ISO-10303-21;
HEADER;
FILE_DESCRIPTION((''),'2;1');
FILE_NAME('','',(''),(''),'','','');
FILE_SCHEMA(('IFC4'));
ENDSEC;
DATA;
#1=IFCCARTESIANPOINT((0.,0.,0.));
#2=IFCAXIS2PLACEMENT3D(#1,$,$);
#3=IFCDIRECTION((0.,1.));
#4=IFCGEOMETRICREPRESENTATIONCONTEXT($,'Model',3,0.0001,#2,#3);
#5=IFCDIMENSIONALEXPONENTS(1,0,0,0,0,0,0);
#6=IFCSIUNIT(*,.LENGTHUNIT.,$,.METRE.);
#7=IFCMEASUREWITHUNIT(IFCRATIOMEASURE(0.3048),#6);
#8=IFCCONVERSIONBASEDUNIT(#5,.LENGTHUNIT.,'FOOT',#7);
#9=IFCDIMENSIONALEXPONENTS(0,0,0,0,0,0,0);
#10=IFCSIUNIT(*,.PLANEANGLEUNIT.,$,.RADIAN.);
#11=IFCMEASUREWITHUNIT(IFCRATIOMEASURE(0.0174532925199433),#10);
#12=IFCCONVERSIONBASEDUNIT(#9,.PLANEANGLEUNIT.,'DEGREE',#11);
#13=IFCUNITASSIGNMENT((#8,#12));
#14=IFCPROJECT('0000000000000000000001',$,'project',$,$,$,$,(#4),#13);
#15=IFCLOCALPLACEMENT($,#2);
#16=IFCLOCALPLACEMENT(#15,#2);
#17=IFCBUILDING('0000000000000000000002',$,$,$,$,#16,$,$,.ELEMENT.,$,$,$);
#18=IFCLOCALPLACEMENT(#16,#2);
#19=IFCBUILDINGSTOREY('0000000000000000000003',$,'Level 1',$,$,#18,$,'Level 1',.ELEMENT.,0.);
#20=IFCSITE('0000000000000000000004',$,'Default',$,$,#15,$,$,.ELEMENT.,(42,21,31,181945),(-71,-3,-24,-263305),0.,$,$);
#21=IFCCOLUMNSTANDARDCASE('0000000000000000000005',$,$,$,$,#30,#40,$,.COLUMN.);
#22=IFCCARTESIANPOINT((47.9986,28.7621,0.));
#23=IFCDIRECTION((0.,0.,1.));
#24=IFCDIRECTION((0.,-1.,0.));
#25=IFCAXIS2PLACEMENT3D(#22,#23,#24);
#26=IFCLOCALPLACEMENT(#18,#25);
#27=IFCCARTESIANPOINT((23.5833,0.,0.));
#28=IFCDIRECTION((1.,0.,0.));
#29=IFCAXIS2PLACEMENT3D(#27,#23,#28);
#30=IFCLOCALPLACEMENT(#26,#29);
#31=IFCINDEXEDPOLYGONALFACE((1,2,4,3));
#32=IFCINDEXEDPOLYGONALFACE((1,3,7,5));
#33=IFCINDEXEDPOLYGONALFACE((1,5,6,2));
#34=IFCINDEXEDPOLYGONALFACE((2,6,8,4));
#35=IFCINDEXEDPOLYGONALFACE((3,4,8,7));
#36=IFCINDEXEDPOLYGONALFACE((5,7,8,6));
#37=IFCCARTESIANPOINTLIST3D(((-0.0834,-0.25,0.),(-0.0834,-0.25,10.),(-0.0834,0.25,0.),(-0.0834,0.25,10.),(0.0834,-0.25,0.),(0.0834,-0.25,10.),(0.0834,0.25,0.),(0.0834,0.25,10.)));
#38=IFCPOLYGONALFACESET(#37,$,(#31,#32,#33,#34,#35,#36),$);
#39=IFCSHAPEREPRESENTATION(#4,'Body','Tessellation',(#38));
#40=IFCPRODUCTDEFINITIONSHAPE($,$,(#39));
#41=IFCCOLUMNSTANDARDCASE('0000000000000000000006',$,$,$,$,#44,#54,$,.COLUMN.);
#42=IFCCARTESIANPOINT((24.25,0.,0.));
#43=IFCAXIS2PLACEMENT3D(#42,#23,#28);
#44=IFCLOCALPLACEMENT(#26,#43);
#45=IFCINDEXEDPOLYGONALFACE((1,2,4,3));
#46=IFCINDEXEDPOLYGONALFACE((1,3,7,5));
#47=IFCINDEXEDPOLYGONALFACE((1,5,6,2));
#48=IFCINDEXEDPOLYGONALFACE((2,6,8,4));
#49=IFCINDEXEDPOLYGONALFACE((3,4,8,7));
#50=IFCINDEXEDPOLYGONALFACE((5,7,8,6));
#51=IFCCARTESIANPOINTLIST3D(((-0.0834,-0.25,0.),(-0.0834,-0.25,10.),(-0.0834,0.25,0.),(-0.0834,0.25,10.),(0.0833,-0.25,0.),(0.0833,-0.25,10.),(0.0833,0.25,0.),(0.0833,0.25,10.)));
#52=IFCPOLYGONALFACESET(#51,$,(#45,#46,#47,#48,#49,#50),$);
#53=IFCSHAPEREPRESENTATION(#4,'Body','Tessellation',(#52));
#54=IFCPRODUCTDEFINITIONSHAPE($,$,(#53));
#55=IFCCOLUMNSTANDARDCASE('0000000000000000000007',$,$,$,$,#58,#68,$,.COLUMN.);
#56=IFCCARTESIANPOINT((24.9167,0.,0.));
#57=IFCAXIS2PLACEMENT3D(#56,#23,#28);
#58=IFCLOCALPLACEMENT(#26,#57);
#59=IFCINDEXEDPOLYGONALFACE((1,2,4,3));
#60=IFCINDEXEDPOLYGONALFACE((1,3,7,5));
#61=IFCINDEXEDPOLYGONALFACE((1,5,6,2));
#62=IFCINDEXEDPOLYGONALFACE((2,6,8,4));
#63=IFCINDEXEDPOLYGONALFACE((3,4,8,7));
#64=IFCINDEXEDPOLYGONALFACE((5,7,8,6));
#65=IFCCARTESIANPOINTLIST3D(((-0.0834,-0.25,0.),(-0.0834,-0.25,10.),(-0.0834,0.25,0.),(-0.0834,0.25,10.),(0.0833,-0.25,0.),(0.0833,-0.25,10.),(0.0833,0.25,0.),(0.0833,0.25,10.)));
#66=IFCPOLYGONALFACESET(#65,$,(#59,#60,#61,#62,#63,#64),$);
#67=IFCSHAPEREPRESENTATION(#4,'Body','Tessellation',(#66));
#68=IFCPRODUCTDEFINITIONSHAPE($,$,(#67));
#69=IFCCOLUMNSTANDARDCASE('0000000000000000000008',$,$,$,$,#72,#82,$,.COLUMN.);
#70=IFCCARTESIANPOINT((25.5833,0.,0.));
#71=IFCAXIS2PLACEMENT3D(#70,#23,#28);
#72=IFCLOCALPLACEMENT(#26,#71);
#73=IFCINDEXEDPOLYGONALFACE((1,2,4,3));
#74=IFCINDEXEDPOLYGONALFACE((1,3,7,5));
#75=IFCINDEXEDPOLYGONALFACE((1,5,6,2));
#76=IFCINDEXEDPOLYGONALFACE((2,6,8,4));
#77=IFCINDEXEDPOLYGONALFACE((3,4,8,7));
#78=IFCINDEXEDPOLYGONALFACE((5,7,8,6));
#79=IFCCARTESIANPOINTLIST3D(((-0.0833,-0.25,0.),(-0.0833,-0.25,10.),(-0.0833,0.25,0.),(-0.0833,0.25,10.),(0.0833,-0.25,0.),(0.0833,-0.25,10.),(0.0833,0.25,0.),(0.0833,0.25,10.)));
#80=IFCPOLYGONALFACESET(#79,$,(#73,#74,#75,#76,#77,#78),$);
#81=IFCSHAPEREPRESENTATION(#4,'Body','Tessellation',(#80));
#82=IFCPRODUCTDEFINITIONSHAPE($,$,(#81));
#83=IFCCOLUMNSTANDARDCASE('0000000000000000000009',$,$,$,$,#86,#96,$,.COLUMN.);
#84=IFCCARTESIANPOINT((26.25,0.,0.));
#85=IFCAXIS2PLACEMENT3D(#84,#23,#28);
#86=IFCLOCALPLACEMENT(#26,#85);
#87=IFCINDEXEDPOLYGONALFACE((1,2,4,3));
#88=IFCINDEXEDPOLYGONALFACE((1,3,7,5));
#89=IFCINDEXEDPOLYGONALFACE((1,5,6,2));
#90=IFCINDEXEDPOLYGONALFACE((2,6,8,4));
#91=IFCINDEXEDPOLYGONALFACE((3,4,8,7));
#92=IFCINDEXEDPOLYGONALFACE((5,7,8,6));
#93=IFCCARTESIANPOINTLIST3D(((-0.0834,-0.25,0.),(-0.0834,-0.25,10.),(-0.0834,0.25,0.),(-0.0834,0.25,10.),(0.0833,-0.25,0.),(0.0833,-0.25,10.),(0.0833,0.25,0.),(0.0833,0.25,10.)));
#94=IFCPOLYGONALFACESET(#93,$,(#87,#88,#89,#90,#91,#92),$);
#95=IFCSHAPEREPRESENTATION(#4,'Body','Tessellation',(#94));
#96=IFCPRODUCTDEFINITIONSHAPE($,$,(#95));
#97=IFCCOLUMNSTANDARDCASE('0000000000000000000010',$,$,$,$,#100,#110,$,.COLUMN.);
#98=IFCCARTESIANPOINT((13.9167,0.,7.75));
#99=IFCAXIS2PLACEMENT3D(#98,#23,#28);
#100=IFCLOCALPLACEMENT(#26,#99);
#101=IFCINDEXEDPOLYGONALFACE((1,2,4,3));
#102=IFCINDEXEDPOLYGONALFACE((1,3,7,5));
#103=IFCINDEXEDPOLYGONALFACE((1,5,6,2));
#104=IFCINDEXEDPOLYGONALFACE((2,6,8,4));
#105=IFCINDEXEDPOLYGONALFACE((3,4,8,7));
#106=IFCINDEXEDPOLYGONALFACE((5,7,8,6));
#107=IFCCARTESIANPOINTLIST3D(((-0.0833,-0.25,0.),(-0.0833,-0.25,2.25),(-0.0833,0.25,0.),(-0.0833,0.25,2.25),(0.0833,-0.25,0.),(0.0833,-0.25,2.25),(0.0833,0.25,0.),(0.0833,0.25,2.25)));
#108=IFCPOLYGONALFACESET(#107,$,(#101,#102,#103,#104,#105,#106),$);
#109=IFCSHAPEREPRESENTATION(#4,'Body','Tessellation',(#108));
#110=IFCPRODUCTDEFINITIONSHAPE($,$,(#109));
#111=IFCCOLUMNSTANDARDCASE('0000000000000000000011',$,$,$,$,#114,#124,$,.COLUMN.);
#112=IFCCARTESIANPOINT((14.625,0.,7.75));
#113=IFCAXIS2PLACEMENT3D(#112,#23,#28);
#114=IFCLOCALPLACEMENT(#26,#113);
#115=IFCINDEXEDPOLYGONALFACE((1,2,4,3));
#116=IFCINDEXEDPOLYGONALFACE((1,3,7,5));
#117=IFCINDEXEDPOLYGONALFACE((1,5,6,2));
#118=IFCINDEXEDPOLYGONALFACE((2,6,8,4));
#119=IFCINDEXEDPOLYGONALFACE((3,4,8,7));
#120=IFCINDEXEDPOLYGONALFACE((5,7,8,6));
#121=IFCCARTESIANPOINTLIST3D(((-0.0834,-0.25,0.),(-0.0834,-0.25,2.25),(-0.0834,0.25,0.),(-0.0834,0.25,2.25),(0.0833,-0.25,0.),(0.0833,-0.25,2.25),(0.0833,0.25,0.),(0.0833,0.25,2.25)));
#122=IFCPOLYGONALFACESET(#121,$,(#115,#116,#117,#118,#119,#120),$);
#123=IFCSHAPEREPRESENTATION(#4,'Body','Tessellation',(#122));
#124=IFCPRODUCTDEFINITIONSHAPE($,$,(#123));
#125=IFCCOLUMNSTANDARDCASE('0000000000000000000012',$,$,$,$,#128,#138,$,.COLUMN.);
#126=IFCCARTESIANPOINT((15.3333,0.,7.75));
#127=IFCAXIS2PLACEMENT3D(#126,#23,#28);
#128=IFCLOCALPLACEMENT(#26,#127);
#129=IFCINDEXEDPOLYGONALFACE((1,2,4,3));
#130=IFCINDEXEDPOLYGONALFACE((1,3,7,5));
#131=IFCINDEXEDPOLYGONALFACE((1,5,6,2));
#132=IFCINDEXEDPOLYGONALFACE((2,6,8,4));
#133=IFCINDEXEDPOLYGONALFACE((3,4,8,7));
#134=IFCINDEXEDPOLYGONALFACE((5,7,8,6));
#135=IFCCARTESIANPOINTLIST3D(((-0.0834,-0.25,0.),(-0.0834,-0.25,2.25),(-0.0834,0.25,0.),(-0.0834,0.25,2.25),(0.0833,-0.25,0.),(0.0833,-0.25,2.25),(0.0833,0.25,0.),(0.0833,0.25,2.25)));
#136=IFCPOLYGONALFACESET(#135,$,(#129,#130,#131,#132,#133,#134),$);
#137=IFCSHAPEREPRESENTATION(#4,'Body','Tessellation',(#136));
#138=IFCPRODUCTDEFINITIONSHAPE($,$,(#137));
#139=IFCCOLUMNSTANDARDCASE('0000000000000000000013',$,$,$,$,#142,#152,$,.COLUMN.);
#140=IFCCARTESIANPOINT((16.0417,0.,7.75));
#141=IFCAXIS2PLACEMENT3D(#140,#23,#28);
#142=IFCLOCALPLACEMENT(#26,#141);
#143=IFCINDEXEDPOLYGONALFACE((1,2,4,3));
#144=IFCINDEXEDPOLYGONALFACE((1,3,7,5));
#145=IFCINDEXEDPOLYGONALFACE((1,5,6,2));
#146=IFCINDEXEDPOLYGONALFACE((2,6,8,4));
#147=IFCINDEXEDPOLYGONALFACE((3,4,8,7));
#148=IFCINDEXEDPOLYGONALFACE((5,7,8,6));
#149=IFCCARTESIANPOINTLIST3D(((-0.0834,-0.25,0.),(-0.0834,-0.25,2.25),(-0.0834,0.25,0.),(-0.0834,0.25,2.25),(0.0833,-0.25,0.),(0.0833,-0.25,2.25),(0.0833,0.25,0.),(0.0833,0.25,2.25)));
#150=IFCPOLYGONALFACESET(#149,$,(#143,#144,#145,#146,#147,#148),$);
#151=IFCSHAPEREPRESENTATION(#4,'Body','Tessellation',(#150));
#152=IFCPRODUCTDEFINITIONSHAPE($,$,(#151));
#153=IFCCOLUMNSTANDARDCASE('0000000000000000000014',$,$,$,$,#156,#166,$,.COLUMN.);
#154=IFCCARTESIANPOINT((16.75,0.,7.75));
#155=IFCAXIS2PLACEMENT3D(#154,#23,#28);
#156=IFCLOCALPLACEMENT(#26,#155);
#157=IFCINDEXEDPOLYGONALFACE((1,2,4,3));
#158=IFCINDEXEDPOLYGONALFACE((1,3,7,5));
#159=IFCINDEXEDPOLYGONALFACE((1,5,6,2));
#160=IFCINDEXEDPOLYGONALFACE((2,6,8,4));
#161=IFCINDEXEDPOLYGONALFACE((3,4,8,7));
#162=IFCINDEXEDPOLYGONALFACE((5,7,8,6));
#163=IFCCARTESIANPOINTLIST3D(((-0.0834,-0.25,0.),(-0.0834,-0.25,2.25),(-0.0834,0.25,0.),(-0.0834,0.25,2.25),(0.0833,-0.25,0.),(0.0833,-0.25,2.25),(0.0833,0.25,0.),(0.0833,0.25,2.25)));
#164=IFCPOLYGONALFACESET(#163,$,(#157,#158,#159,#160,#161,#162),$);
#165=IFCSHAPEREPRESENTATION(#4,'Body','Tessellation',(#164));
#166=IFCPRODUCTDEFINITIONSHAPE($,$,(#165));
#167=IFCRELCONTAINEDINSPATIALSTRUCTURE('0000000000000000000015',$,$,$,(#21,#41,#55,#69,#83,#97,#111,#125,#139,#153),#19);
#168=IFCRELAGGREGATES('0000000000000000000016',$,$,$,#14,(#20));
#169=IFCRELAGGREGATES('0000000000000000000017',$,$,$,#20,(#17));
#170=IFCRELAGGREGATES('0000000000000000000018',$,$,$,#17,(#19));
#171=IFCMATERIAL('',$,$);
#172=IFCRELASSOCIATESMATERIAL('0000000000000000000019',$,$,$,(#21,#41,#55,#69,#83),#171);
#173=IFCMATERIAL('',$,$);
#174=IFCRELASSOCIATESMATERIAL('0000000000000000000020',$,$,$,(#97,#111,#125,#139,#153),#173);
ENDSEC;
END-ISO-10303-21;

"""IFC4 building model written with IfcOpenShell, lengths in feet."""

from ifc_helpers import new_model, entity, si_unit, converted_unit, direction, frame, origin, place, context, project, spatial, rectangle, extrude, material, element, save


model = new_model("IFC4")

# Units and contexts
model_context = context("Model", 3, precision=0.0001, world=origin(), true_north=direction((0.0, 1.0)))
ifc_project = project(units=[converted_unit("LENGTHUNIT", "FOOT", entity("IfcRatioMeasure", 0.3048), si_unit("LENGTHUNIT", "METRE"), dimensions=[1, 0, 0, 0, 0, 0, 0]), converted_unit("PLANEANGLEUNIT", "DEGREE", entity("IfcRatioMeasure", 0.0174532925199433), si_unit("PLANEANGLEUNIT", "RADIAN"), dimensions=[0, 0, 0, 0, 0, 0, 0])], contexts=[model_context])

# Site, building, storey
site_placement = place(None, origin())
site = spatial("IfcSite", under=ifc_project, at=site_placement, Name="Default", CompositionType="ELEMENT", RefLatitude=(42, 21, 31, 181945), RefLongitude=(-71, -3, -24, -263305), RefElevation=0.0)
building_placement = place(site_placement, origin())
building = spatial("IfcBuilding", under=site, at=building_placement, CompositionType="ELEMENT")
storey_placement = place(building_placement, origin())
storey = spatial("IfcBuildingStorey", under=building, at=storey_placement, Name="Level 1", LongName="Level 1", CompositionType="ELEMENT", Elevation=0.0)

# Columns
placement_1 = place(storey_placement, frame((47.9986, 28.7621, 0.0), z_axis=(0.0, 0.0, 1.0), x_axis=(0.0, -1.0, 0.0)))
ifc_material_1 = material(Name="")
for number, where, z_axis, x_axis in (
    (1, (23.5833, 0.0, 0.0), (0.0, 0.0, 1.0), (1.0, 0.0, 0.0)),
    (2, (24.25, 0.0, 0.0), (0.0, 0.0, 1.0), (1.0, 0.0, 0.0)),
    (3, (24.9167, 0.0, 0.0), (0.0, 0.0, 1.0), (1.0, 0.0, 0.0)),
    (4, (25.5833, 0.0, 0.0), (0.0, 0.0, 1.0), (1.0, 0.0, 0.0)),
    (5, (26.25, 0.0, 0.0), (0.0, 0.0, 1.0), (1.0, 0.0, 0.0)),
):
    element("IfcColumnStandardCase", number, at=place(placement_1, frame(where, z_axis=z_axis, x_axis=x_axis)), inside=storey, material=ifc_material_1, PredefinedType="COLUMN", context=model_context, shape_type="SweptSolid", body=[
        extrude(rectangle(XDim=0.1667, YDim=0.5), origin(), (0.0, 0.0, 1.0), 10.0),
    ])
ifc_material_2 = material(Name="")
for number, where, z_axis, x_axis in (
    (6, (13.9167, 0.0, 7.75), (0.0, 0.0, 1.0), (1.0, 0.0, 0.0)),
    (7, (14.625, 0.0, 7.75), (0.0, 0.0, 1.0), (1.0, 0.0, 0.0)),
    (8, (15.3333, 0.0, 7.75), (0.0, 0.0, 1.0), (1.0, 0.0, 0.0)),
    (9, (16.0417, 0.0, 7.75), (0.0, 0.0, 1.0), (1.0, 0.0, 0.0)),
    (10, (16.75, 0.0, 7.75), (0.0, 0.0, 1.0), (1.0, 0.0, 0.0)),
):
    element("IfcColumnStandardCase", number, at=place(placement_1, frame(where, z_axis=z_axis, x_axis=x_axis)), inside=storey, material=ifc_material_2, PredefinedType="COLUMN", context=model_context, shape_type="SweptSolid", body=[
        extrude(rectangle(XDim=0.1667, YDim=0.5), origin(), (0.0, 0.0, 1.0), 2.25),
    ])

save(model, "model.ifc")
